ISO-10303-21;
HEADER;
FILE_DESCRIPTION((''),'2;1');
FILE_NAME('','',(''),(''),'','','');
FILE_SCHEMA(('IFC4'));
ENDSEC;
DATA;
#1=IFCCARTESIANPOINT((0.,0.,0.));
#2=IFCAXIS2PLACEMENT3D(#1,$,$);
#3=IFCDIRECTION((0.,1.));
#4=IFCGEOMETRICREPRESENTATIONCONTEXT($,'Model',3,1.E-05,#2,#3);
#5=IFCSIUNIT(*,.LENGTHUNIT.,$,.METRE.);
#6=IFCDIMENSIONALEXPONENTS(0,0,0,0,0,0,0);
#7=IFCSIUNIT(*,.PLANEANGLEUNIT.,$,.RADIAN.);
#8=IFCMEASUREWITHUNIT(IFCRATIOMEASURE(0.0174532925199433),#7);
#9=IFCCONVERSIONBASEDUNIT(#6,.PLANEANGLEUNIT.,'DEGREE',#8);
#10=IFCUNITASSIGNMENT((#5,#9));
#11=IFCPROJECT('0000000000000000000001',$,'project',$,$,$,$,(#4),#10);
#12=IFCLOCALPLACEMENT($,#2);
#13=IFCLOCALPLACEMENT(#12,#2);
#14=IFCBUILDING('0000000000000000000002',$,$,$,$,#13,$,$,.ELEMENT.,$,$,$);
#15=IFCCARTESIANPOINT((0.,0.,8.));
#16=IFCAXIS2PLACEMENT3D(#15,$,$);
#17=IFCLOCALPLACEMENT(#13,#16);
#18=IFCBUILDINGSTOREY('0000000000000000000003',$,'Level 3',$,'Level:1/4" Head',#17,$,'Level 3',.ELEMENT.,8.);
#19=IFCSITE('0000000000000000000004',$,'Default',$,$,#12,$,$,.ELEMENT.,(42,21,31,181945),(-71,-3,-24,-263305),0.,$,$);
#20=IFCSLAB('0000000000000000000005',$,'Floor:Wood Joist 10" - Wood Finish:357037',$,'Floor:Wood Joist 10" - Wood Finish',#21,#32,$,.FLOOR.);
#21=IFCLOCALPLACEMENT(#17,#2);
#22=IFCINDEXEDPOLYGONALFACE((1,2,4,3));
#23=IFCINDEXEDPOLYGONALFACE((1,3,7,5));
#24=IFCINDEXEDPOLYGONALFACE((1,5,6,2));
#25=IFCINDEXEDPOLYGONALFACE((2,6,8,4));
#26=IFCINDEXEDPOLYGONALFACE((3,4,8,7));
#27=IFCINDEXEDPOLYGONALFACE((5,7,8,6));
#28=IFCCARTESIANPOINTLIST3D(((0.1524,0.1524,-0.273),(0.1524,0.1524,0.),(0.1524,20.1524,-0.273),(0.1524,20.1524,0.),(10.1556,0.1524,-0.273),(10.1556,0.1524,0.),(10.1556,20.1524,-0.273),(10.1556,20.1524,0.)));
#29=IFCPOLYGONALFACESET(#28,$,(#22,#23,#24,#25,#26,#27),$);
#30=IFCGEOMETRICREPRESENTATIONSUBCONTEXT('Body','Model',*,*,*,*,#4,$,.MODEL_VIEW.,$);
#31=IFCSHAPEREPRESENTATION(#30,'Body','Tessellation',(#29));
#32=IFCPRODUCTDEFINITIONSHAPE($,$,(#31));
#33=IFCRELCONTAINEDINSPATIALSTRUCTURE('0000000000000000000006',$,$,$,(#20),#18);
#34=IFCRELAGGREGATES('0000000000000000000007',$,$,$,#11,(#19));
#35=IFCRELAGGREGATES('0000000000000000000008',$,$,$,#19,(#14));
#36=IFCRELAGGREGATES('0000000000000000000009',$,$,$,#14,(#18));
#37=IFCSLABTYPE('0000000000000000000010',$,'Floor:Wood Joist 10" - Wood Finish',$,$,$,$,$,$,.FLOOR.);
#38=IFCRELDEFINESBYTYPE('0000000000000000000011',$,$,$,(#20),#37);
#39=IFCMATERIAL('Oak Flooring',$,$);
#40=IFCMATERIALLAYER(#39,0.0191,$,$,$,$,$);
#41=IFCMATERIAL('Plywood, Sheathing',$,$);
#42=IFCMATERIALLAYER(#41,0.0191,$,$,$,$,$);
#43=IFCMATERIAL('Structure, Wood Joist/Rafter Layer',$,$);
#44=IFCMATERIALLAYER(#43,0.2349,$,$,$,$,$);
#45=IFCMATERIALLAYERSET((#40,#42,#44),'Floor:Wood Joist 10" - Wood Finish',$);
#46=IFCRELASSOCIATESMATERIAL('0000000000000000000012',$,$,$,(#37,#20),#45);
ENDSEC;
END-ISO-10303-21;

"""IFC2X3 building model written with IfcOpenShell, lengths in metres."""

from ifc_helpers import new_model, entity, si_unit, converted_unit, direction, frame, origin, origin_2d_with_axis, place, context, subcontext, project, spatial, rectangle, extrude, material, layer, layer_set, layer_usage, type_object, element, save


model = new_model("IFC2X3")

# Units and contexts
model_context = context("Model", 3, precision=1e-05, world=origin(), true_north=direction((0.0, 1.0)))
body_context = subcontext(model_context, "Body", "Model", "MODEL_VIEW")
ifc_project = project(units=[si_unit("LENGTHUNIT", "METRE"), converted_unit("PLANEANGLEUNIT", "DEGREE", entity("IfcRatioMeasure", 0.0174532925199433), si_unit("PLANEANGLEUNIT", "RADIAN"), dimensions=[0, 0, 0, 0, 0, 0, 0])], contexts=[model_context])

# Site, building, storey
site_placement = place(None, origin())
site = spatial("IfcSite", under=ifc_project, at=site_placement, Name="Default", CompositionType="ELEMENT", RefLatitude=(42, 21, 31, 181945), RefLongitude=(-71, -3, -24, -263305), RefElevation=0.0)
building_placement = place(site_placement, origin())
building = spatial("IfcBuilding", under=site, at=building_placement, CompositionType="ELEMENT")
storey_placement = place(building_placement, frame((0.0, 0.0, 8.0)))
storey = spatial("IfcBuildingStorey", under=building, at=storey_placement, Name="Level 3", ObjectType="Level:1/4\" Head", LongName="Level 3", CompositionType="ELEMENT", Elevation=8.0)

# Slab
ifc_material_1 = material(Name="Oak Flooring")
ifc_layer_1 = layer(ifc_material_1, 0.0191)
ifc_material_2 = material(Name="Plywood, Sheathing")
ifc_layer_2 = layer(ifc_material_2, 0.0191)
ifc_material_3 = material(Name="Structure, Wood Joist/Rafter Layer")
ifc_layer_3 = layer(ifc_material_3, 0.2349)
ifc_layer_set = layer_set([ifc_layer_1, ifc_layer_2, ifc_layer_3], Name="Floor:Wood Joist 10\" - Wood Finish")
ifc_layer_usage = layer_usage(ifc_layer_set, "AXIS3", "POSITIVE", 0.0)
slab_type = type_object("IfcSlabType", Name="Floor:Wood Joist 10\" - Wood Finish", PredefinedType="FLOOR", material=ifc_layer_set)
slab_placement = place(storey_placement, origin())
element("IfcSlab", 1, at=slab_placement, inside=storey, type_object=slab_type, material=ifc_layer_usage, Name="Floor:Wood Joist 10\" - Wood Finish:357037", ObjectType="Floor:Wood Joist 10\" - Wood Finish", PredefinedType="FLOOR", context=body_context, shape_type="SweptSolid", body=[
    extrude(rectangle(XDim=20.0, YDim=10.0032, at=origin_2d_with_axis()), frame((5.154, 10.1524, 0.0), z_axis=(0.0, 0.0, -1.0), x_axis=(0.0, 1.0, 0.0)), (0.0, 0.0, 1.0), 0.2731),
])

save(model, "model.ifc")
